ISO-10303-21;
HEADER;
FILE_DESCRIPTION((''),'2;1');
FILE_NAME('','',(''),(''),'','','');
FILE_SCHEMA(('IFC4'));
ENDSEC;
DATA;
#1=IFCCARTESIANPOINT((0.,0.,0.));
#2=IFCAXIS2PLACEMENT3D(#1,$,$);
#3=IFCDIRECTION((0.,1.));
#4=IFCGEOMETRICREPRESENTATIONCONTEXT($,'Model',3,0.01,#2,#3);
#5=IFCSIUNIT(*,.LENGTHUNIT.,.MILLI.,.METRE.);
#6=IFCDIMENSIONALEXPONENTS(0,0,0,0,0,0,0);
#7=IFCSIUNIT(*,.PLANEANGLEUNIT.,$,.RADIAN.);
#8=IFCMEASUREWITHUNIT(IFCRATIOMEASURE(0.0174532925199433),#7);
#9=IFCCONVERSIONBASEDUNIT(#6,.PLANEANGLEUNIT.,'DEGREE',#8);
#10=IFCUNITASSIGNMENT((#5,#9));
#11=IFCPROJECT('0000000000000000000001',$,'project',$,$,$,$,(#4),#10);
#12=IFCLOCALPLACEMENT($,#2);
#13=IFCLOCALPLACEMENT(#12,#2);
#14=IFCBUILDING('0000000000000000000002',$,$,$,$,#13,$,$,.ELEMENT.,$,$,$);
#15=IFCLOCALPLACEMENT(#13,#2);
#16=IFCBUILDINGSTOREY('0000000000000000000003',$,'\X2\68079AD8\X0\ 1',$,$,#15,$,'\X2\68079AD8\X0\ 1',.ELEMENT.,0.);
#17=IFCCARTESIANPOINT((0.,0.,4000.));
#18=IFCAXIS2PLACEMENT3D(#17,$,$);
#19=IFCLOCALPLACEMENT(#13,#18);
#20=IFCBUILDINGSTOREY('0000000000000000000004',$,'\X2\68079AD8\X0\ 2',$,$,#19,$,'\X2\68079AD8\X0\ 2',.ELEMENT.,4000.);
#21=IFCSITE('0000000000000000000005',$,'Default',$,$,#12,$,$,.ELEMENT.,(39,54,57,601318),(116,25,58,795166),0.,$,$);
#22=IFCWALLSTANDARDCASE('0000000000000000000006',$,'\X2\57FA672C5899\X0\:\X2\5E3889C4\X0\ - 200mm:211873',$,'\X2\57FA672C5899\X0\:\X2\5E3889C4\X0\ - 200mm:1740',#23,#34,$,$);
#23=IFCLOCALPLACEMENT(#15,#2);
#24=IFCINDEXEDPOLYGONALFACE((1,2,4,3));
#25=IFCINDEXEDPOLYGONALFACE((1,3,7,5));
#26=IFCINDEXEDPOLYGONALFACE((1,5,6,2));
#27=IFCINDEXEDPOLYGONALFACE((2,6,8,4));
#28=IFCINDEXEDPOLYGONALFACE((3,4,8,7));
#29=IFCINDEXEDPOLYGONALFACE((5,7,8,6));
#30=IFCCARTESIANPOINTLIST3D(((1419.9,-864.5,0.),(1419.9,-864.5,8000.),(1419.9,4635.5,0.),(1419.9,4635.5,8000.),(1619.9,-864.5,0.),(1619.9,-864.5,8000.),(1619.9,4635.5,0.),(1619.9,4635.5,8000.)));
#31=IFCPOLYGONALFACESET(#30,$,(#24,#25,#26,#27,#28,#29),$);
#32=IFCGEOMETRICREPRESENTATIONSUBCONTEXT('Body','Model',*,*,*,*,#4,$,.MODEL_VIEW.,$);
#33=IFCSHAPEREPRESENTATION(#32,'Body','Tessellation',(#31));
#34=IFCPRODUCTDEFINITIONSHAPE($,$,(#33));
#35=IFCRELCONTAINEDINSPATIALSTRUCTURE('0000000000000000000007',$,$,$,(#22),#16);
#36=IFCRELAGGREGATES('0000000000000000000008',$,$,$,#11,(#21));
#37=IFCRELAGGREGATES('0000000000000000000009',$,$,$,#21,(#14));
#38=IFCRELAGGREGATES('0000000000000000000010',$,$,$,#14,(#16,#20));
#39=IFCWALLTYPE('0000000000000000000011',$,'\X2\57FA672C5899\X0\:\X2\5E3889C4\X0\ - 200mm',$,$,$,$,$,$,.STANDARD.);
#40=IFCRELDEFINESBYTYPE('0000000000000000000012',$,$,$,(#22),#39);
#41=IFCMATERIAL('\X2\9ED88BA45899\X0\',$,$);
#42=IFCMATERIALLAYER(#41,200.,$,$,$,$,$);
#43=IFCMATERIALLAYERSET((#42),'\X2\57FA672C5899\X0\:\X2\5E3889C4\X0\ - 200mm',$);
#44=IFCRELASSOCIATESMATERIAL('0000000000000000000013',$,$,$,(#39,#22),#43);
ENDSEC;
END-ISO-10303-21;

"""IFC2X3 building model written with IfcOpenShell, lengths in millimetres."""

from ifc_helpers import new_model, entity, si_unit, converted_unit, direction, frame, frame_2d, origin, place, context, subcontext, project, spatial, rectangle, extrude, material, layer, layer_set, layer_usage, type_object, element, save


model = new_model("IFC2X3")

# Units and contexts
model_context = context("Model", 3, precision=0.01, world=origin(), true_north=direction((0.0, 1.0)))
body_context = subcontext(model_context, "Body", "Model", "MODEL_VIEW")
ifc_project = project(units=[si_unit("LENGTHUNIT", "METRE", prefix="MILLI"), converted_unit("PLANEANGLEUNIT", "DEGREE", entity("IfcRatioMeasure", 0.0174532925199433), si_unit("PLANEANGLEUNIT", "RADIAN"), dimensions=[0, 0, 0, 0, 0, 0, 0])], contexts=[model_context])

# Site, building, storey
site_placement = place(None, origin())
site = spatial("IfcSite", under=ifc_project, at=site_placement, Name="Default", CompositionType="ELEMENT", RefLatitude=(39, 54, 57, 601318), RefLongitude=(116, 25, 58, 795166), RefElevation=0.0)
building_placement = place(site_placement, origin())
building = spatial("IfcBuilding", under=site, at=building_placement, CompositionType="ELEMENT")
storey_1_placement = place(building_placement, origin())
storey_1 = spatial("IfcBuildingStorey", under=building, at=storey_1_placement, Name="标高 1", LongName="标高 1", CompositionType="ELEMENT", Elevation=0.0)

# Shared definitions
ifc_material_1 = material(Name="默认墙")
ifc_layer_1 = layer(ifc_material_1, 200.0)
ifc_layer_set_1 = layer_set([ifc_layer_1], Name="基本墙:常规 - 200mm")
wall_type_1 = type_object("IfcWallType", Name="基本墙:常规 - 200mm", PredefinedType="STANDARD", material=ifc_layer_set_1)

# Wall
ifc_layer_usage_1 = layer_usage(ifc_layer_set_1, "AXIS2", "NEGATIVE", 100.0)
wall_1_placement = place(storey_1_placement, frame((1519.9, 4635.5, 0.0), z_axis=(0.0, 0.0, 1.0), x_axis=(0.0, -1.0, 0.0)))
element("IfcWallStandardCase", 1, at=wall_1_placement, inside=storey_1, type_object=wall_type_1, material=ifc_layer_usage_1, Name="基本墙:常规 - 200mm:211873", ObjectType="基本墙:常规 - 200mm:1740", context=body_context, shape_type="SweptSolid", body=[
    extrude(rectangle(XDim=5500.0, YDim=200.0, at=frame_2d((2750.0, 0.0), x_axis=(-1.0, 0.0))), origin(), (0.0, 0.0, 1.0), 8000.0),
])

# Shared definitions
storey_2_placement = place(building_placement, frame((0.0, 0.0, 4000.0)))
storey_2 = spatial("IfcBuildingStorey", under=building, at=storey_2_placement, Name="标高 2", LongName="标高 2", CompositionType="ELEMENT", Elevation=4000.0)

save(model, "model.ifc")
